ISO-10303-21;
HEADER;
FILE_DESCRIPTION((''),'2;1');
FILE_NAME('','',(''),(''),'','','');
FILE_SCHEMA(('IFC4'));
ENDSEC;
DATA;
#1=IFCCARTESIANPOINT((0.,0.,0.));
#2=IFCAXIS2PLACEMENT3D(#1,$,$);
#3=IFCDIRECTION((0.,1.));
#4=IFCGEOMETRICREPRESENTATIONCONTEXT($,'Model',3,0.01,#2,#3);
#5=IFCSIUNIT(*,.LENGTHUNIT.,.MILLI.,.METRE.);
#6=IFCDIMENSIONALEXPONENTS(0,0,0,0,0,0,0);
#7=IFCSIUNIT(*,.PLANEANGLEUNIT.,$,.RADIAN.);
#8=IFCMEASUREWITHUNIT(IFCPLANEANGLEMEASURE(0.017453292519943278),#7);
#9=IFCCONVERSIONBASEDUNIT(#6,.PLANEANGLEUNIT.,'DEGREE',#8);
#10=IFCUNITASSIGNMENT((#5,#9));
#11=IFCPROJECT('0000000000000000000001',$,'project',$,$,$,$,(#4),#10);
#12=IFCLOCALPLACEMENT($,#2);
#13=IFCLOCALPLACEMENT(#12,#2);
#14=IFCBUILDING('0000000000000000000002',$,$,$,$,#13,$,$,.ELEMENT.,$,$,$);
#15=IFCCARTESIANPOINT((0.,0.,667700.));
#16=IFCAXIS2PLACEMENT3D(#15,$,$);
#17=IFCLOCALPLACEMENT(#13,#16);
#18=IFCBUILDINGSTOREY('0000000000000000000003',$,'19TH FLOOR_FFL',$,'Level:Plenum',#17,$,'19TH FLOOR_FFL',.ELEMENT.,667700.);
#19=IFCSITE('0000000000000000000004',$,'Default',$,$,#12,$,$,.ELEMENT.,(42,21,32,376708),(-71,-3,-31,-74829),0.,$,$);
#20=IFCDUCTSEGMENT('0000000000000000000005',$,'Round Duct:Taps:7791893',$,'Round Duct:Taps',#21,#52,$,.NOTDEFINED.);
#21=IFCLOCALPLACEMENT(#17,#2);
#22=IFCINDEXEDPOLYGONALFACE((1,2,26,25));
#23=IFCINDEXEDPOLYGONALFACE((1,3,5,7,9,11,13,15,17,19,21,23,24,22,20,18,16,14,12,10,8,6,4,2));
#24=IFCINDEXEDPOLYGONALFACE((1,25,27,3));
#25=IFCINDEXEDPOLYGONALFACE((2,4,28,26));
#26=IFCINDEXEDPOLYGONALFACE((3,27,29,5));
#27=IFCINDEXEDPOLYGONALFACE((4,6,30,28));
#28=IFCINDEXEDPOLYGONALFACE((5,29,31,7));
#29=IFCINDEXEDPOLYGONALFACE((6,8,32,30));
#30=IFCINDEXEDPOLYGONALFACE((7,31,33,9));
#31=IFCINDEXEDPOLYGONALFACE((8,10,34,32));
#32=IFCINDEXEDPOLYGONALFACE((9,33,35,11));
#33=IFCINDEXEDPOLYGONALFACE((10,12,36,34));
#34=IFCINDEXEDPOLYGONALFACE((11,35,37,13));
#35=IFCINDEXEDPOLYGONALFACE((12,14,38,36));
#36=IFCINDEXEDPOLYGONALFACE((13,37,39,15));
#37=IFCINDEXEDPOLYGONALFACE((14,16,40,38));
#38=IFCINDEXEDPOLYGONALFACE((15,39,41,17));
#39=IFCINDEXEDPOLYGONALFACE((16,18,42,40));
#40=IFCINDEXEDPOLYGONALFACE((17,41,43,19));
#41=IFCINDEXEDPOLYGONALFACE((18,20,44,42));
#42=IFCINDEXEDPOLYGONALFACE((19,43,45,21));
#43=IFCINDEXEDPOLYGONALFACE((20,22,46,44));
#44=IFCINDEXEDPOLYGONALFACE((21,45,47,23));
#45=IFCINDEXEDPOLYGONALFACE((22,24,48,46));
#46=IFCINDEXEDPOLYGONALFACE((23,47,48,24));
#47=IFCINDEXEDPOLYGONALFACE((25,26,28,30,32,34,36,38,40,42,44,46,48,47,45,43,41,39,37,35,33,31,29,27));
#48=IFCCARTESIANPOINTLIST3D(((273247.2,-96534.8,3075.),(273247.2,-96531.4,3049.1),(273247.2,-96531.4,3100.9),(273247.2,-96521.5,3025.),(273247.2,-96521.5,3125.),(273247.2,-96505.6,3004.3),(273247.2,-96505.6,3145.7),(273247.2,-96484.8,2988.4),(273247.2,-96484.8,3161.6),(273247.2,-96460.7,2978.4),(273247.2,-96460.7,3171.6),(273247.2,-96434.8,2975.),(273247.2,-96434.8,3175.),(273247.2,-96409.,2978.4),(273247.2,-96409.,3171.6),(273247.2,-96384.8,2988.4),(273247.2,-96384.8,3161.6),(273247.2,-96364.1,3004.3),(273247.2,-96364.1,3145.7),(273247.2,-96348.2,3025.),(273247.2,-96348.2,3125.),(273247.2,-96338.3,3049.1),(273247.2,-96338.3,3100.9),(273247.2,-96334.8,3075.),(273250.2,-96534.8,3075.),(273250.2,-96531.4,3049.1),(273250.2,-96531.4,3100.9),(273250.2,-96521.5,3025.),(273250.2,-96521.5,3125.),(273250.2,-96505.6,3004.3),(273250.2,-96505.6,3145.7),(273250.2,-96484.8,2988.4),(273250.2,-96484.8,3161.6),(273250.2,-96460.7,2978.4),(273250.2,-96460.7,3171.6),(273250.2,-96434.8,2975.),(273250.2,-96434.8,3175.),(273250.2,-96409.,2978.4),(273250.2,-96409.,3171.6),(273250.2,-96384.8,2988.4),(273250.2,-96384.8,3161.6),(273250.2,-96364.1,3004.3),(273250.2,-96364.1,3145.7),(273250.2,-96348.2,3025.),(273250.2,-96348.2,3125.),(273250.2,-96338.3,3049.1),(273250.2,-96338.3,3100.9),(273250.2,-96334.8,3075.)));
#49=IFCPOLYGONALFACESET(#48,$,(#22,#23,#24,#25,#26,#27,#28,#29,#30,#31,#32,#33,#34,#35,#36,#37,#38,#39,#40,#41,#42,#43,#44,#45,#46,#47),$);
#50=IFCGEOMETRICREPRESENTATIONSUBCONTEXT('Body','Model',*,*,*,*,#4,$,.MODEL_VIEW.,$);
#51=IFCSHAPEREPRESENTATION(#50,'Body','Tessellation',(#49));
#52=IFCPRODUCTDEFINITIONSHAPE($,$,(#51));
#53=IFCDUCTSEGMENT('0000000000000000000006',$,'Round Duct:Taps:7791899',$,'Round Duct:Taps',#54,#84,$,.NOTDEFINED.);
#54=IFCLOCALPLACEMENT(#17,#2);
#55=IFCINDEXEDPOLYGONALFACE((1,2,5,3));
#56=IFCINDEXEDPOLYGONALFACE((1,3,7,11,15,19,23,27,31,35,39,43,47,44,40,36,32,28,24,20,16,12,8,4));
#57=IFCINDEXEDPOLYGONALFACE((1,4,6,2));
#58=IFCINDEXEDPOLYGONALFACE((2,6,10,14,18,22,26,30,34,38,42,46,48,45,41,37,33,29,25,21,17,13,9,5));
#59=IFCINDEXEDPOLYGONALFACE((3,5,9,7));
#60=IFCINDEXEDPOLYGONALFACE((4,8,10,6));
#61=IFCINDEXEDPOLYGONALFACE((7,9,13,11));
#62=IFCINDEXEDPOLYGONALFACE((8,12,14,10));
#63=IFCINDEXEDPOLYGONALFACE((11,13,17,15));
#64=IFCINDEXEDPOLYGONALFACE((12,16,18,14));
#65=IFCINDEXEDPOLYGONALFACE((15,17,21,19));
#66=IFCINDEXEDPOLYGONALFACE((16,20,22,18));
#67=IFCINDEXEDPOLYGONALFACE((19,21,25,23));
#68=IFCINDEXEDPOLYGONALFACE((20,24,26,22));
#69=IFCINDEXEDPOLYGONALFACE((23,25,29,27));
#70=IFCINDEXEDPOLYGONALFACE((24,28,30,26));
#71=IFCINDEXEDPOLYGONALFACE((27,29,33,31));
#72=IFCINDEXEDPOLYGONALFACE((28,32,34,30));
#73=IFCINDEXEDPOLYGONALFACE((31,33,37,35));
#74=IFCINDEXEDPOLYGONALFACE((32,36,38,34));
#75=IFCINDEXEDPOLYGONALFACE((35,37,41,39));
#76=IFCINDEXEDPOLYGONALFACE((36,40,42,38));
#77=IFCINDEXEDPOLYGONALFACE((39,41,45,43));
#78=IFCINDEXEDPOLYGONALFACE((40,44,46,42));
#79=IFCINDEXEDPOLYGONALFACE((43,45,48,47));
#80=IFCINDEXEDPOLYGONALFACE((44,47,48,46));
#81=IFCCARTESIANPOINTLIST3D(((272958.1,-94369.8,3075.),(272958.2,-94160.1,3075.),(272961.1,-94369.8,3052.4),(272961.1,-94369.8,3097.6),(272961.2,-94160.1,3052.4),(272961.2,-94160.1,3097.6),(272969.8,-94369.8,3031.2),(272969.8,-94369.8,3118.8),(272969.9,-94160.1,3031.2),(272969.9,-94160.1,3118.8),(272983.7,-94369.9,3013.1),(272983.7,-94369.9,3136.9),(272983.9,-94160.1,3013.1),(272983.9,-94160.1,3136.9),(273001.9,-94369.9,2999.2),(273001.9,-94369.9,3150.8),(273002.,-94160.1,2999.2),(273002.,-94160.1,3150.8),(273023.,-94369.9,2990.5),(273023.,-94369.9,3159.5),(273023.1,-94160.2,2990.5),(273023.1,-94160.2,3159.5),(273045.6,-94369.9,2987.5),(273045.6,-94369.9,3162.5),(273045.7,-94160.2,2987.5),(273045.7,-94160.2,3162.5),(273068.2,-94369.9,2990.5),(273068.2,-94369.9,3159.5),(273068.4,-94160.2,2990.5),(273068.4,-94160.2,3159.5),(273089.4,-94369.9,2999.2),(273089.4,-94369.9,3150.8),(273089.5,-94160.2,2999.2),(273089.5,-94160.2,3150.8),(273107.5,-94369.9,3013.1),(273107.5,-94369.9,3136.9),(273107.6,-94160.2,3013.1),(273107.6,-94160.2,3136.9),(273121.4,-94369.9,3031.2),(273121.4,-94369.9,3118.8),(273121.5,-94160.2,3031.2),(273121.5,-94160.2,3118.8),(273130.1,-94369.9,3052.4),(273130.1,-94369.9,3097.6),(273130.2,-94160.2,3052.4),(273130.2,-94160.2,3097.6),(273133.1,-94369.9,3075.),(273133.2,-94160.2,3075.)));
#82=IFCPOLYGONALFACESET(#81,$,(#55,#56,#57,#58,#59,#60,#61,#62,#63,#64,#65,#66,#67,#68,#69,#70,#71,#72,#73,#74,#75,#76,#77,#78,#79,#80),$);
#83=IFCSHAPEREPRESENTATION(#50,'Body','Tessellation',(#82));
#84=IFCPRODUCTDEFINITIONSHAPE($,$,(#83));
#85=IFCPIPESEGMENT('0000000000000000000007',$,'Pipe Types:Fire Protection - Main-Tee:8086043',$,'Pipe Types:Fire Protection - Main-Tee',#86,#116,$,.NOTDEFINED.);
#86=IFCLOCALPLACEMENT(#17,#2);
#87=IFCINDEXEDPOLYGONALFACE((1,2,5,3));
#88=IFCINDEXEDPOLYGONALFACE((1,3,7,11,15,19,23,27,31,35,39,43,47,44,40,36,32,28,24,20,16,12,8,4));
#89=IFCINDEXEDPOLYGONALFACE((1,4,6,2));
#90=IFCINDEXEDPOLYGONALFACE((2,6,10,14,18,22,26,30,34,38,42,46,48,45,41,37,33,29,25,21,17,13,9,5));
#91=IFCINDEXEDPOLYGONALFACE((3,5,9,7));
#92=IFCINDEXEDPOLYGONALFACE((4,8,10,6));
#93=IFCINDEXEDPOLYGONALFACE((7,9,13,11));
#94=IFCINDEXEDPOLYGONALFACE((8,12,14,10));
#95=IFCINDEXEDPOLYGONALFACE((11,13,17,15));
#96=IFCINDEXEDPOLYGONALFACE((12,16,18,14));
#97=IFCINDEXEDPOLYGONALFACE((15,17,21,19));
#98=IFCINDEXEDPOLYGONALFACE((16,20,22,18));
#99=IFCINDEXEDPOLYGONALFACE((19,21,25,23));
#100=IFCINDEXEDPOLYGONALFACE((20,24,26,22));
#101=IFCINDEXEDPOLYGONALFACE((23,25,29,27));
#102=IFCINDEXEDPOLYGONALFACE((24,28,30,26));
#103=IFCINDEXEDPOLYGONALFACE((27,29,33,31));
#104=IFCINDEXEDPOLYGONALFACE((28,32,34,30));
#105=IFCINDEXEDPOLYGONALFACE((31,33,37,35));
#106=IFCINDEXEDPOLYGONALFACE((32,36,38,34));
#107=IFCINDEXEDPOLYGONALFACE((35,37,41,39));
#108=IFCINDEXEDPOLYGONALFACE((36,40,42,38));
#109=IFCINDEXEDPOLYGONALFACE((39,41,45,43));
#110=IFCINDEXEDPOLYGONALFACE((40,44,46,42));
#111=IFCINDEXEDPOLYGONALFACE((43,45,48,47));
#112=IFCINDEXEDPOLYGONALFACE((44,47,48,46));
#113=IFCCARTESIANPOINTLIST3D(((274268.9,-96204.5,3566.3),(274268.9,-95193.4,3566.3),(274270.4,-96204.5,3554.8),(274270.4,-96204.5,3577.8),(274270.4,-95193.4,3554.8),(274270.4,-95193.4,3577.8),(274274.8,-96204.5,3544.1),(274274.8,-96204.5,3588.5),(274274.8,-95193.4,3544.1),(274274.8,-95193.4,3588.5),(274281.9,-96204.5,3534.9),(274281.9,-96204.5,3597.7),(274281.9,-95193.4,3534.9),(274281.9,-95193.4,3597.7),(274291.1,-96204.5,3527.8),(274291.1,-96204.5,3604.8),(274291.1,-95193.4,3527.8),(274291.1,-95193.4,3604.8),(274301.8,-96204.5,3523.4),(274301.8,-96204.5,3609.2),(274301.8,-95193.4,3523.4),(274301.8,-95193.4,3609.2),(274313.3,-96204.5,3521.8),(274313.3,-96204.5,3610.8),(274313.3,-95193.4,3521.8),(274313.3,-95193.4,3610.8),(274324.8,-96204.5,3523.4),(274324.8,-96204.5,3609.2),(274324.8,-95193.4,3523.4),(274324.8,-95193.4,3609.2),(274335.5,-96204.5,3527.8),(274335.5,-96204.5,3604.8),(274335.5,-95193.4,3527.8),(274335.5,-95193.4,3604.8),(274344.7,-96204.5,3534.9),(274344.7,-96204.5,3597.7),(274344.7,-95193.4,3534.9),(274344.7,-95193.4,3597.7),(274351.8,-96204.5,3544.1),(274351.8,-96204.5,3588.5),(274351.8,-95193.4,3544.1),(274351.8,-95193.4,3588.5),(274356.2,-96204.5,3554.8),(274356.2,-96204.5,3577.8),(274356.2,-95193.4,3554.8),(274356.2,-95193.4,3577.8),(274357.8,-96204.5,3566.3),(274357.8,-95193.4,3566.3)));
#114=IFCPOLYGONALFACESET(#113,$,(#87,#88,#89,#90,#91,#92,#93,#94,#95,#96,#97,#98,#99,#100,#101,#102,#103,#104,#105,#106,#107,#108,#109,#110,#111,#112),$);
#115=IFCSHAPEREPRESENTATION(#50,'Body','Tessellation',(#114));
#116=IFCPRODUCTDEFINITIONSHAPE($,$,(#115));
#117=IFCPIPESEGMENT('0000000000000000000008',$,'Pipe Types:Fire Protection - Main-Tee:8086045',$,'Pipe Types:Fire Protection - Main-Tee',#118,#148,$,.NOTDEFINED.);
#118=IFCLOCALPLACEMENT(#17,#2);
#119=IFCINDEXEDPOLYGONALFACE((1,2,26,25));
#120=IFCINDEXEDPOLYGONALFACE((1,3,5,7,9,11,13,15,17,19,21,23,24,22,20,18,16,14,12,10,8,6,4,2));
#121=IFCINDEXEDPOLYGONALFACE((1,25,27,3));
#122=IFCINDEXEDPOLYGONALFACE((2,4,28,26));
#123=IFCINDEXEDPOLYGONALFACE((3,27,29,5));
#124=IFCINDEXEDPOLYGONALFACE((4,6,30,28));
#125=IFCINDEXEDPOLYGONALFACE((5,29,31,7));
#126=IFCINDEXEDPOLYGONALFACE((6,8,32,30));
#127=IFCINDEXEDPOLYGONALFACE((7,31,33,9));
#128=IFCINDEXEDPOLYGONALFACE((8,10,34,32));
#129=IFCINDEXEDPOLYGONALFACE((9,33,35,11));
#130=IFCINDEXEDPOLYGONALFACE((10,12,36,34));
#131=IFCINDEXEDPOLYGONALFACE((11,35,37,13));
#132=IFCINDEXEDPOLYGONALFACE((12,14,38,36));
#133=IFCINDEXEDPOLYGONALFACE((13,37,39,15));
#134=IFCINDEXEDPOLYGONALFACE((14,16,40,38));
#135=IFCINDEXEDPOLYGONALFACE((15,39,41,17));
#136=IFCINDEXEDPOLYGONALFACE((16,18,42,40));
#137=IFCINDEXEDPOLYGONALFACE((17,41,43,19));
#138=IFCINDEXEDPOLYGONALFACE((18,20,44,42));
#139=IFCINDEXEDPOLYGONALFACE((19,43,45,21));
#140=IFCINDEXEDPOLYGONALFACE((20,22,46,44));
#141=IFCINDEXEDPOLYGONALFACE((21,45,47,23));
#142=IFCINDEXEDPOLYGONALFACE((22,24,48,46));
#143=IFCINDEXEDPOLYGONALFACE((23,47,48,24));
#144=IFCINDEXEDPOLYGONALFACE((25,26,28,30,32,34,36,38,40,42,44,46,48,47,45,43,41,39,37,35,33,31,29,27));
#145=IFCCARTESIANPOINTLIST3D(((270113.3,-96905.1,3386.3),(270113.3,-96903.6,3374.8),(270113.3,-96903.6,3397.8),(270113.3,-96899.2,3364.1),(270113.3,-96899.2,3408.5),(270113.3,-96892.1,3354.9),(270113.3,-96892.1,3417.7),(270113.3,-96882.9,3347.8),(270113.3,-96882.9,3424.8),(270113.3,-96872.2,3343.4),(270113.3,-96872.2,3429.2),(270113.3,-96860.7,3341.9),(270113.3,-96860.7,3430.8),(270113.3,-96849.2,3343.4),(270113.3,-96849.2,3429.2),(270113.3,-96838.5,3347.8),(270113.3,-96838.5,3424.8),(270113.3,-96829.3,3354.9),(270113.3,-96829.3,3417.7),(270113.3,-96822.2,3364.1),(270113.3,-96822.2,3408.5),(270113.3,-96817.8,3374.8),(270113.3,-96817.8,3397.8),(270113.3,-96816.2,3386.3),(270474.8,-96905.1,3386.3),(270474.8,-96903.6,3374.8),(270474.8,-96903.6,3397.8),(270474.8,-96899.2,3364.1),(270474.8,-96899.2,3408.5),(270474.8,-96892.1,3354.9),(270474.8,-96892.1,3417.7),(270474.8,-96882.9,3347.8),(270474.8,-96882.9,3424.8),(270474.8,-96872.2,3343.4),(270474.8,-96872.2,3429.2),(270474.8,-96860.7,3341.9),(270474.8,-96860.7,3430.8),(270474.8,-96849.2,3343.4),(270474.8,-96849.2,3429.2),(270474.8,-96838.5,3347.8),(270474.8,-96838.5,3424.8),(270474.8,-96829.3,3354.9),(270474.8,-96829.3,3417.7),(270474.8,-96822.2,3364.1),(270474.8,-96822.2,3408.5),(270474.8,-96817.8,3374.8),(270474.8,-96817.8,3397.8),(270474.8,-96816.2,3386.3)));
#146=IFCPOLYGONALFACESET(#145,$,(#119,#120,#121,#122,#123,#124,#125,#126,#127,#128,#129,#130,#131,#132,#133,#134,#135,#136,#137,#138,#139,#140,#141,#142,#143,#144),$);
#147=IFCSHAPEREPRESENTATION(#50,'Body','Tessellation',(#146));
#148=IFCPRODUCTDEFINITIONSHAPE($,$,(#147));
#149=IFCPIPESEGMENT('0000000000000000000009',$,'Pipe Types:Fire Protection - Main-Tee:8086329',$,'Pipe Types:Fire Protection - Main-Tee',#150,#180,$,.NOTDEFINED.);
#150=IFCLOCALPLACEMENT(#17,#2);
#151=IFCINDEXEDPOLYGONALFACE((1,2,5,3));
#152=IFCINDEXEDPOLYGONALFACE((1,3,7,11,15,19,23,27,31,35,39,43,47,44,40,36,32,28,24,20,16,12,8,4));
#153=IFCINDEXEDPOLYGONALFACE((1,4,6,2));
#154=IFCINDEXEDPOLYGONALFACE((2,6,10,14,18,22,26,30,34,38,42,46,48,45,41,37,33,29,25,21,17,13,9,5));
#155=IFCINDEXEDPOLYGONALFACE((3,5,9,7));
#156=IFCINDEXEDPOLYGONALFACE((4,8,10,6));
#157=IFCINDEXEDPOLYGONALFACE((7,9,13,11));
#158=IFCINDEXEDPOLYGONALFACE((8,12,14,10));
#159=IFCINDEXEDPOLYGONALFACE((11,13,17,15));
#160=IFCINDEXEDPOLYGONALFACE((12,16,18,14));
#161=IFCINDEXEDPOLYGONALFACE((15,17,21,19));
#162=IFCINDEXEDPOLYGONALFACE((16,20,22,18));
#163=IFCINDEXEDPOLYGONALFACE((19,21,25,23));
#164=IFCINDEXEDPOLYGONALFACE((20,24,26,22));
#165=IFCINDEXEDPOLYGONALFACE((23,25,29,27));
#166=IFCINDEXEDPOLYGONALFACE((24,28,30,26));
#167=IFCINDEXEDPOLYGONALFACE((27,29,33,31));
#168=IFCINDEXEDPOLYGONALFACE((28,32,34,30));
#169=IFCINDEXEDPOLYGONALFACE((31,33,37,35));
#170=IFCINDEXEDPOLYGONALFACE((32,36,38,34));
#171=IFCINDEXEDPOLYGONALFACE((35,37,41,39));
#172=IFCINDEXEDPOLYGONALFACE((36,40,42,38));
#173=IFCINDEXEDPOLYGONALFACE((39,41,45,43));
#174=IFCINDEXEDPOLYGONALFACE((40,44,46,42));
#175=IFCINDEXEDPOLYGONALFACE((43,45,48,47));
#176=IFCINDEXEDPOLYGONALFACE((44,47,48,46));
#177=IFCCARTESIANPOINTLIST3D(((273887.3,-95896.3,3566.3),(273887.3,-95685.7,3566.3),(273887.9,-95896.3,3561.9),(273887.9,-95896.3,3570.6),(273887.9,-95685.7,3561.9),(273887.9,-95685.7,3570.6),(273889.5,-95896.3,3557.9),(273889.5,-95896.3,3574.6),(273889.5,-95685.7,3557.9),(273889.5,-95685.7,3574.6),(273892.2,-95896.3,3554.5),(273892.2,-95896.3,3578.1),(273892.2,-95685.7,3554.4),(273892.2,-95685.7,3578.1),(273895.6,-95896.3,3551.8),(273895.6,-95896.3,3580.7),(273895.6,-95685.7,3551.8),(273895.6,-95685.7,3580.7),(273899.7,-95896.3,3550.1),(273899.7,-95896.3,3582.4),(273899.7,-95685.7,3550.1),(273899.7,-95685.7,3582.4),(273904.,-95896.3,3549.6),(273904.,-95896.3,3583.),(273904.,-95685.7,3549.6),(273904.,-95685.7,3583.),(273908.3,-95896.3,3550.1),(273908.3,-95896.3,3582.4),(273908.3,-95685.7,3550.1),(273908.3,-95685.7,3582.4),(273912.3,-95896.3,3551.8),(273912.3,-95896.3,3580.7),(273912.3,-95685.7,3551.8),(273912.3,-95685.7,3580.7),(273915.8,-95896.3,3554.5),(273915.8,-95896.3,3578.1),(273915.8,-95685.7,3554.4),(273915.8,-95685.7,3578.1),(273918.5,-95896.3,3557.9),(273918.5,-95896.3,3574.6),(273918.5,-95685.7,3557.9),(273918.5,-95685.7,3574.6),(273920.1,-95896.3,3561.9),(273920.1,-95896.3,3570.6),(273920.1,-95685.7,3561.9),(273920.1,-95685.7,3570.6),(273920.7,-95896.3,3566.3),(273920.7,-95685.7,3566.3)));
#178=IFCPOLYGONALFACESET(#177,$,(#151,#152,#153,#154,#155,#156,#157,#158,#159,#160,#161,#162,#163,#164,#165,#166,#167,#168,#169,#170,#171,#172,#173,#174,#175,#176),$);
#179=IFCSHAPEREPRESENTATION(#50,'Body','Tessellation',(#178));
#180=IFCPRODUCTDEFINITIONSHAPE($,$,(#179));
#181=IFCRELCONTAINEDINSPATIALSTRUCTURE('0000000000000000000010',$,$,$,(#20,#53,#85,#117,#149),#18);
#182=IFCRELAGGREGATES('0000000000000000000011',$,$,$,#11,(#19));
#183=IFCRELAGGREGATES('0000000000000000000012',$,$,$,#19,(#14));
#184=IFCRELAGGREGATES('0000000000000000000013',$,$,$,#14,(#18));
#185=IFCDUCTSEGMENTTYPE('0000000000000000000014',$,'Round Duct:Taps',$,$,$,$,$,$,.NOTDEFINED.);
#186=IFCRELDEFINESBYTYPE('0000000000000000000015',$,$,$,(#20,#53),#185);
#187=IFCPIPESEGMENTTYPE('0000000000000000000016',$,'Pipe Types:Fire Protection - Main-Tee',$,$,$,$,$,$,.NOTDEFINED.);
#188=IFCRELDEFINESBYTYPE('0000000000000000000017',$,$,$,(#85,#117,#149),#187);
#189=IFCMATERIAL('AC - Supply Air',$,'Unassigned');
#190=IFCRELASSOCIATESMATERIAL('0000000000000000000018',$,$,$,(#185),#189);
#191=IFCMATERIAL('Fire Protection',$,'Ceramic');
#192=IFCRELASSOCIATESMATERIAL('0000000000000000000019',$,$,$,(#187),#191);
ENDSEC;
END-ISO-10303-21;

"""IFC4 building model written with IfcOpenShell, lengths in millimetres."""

from ifc_helpers import new_model, entity, si_unit, converted_unit, direction, frame, origin, place, context, subcontext, project, spatial, arc, indexed_curve, outline, extrude, material, type_object, element, save


model = new_model("IFC4")

# Units and contexts
model_context = context("Model", 3, precision=0.01, world=origin(), true_north=direction((0.0, 1.0)))
body_context = subcontext(model_context, "Body", "Model", "MODEL_VIEW")
ifc_project = project(units=[si_unit("LENGTHUNIT", "METRE", prefix="MILLI"), converted_unit("PLANEANGLEUNIT", "DEGREE", entity("IfcPlaneAngleMeasure", 0.017453292519943278), si_unit("PLANEANGLEUNIT", "RADIAN"), dimensions=[0, 0, 0, 0, 0, 0, 0])], contexts=[model_context])

# Site, building, storey
site_placement = place(None, origin())
site = spatial("IfcSite", under=ifc_project, at=site_placement, Name="Default", CompositionType="ELEMENT", RefLatitude=(42, 21, 32, 376708), RefLongitude=(-71, -3, -31, -74829), RefElevation=0.0)
building_placement = place(site_placement, origin())
building = spatial("IfcBuilding", under=site, at=building_placement, CompositionType="ELEMENT")
storey_placement = place(building_placement, frame((0.0, 0.0, 667700.0)))
storey = spatial("IfcBuildingStorey", under=building, at=storey_placement, Name="19TH FLOOR_FFL", ObjectType="Level:Plenum", LongName="19TH FLOOR_FFL", CompositionType="ELEMENT", Elevation=667700.0)

# Duct segments
ifc_material_1 = material(Name="AC - Supply Air", Category="Unassigned")
duct_segment_type_1 = type_object("IfcDuctSegmentType", Name="Round Duct:Taps", PredefinedType="NOTDEFINED", material=ifc_material_1)
duct_segment_1_placement = place(storey_placement, origin())
element("IfcDuctSegment", 1, at=duct_segment_1_placement, inside=storey, type_object=duct_segment_type_1, Name="Round Duct:Taps:7791893", ObjectType="Round Duct:Taps", PredefinedType="NOTDEFINED", context=body_context, shape_type="SweptSolid", body=[
    extrude(outline(indexed_curve([(100.0, 0.0), (70.7, 70.7), (0.0, 100.0), (-70.7, 70.7), (-100.0, 0.0), (-70.7, -70.7), (0.0, -100.0), (70.7, -70.7)], segments=[arc(1, 2, 3), arc(3, 4, 5), arc(5, 6, 7), arc(7, 8, 1)], self_intersect=False)), frame((273247.2, -96434.8, 3075.0), z_axis=(1.0, 0.0, 0.0), x_axis=(0.0, -1.0, 0.0)), (0.0, 0.0, 1.0), 3.0),
])
duct_segment_2_placement = place(storey_placement, origin())
element("IfcDuctSegment", 2, at=duct_segment_2_placement, inside=storey, type_object=duct_segment_type_1, Name="Round Duct:Taps:7791899", ObjectType="Round Duct:Taps", PredefinedType="NOTDEFINED", context=body_context, shape_type="SweptSolid", body=[
    extrude(outline(indexed_curve([(87.5, 0.0), (61.9, 61.9), (0.0, 87.5), (-61.9, 61.9), (-87.5, 0.0), (-61.9, -61.9), (0.0, -87.5), (61.9, -61.9)], segments=[arc(1, 2, 3), arc(3, 4, 5), arc(5, 6, 7), arc(7, 8, 1)], self_intersect=False)), frame((273045.6, -94369.9, 3075.0), z_axis=(0.000583, 1.0, 0.0), x_axis=(1.0, -0.000583, 0.0)), (0.0, 0.0, 1.0), 209.7),
])

# Pipe segments
ifc_material_2 = material(Name="Fire Protection", Category="Ceramic")
pipe_segment_type = type_object("IfcPipeSegmentType", Name="Pipe Types:Fire Protection - Main-Tee", PredefinedType="NOTDEFINED", material=ifc_material_2)
pipe_segment_1_placement = place(storey_placement, origin())
element("IfcPipeSegment", 3, at=pipe_segment_1_placement, inside=storey, type_object=pipe_segment_type, Name="Pipe Types:Fire Protection - Main-Tee:8086043", ObjectType="Pipe Types:Fire Protection - Main-Tee", PredefinedType="NOTDEFINED", context=body_context, shape_type="SweptSolid", body=[
    extrude(outline(indexed_curve([(44.5, 0.0), (31.4, 31.4), (0.0, 44.5), (-31.4, 31.4), (-44.4, 0.0), (-31.4, -31.4), (0.0, -44.5), (31.4, -31.4)], segments=[arc(1, 2, 3), arc(3, 4, 5), arc(5, 6, 7), arc(7, 8, 1)], self_intersect=False)), frame((274313.3, -96204.5, 3566.3), z_axis=(0.0, 1.0, 0.0), x_axis=(1.0, 0.0, 0.0)), (0.0, 0.0, 1.0), 1011.2),
])
pipe_segment_2_placement = place(storey_placement, origin())
element("IfcPipeSegment", 4, at=pipe_segment_2_placement, inside=storey, type_object=pipe_segment_type, Name="Pipe Types:Fire Protection - Main-Tee:8086045", ObjectType="Pipe Types:Fire Protection - Main-Tee", PredefinedType="NOTDEFINED", context=body_context, shape_type="SweptSolid", body=[
    extrude(outline(indexed_curve([(44.4, 0.0), (31.4, 31.4), (0.0, 44.5), (-31.4, 31.4), (-44.4, 0.0), (-31.4, -31.4), (0.0, -44.5), (31.4, -31.4)], segments=[arc(1, 2, 3), arc(3, 4, 5), arc(5, 6, 7), arc(7, 8, 1)], self_intersect=False)), frame((270113.3, -96860.7, 3386.3), z_axis=(1.0, 0.0, 0.0), x_axis=(0.0, 1.0, 0.0)), (0.0, 0.0, 1.0), 361.5),
])
pipe_segment_3_placement = place(storey_placement, origin())
element("IfcPipeSegment", 5, at=pipe_segment_3_placement, inside=storey, type_object=pipe_segment_type, Name="Pipe Types:Fire Protection - Main-Tee:8086329", ObjectType="Pipe Types:Fire Protection - Main-Tee", PredefinedType="NOTDEFINED", context=body_context, shape_type="SweptSolid", body=[
    extrude(outline(indexed_curve([(16.7, 0.0), (11.8, 11.8), (0.0, 16.7), (-11.8, 11.8), (-16.7, 0.0), (-11.8, -11.8), (0.0, -16.7), (11.8, -11.8)], segments=[arc(1, 2, 3), arc(3, 4, 5), arc(5, 6, 7), arc(7, 8, 1)], self_intersect=False)), frame((273904.0, -95896.3, 3566.3), z_axis=(0.0, 1.0, -0.000043), x_axis=(1.0, 0.0, 0.0)), (0.0, 0.0, 1.0), 210.6),
])

save(model, "model.ifc")
